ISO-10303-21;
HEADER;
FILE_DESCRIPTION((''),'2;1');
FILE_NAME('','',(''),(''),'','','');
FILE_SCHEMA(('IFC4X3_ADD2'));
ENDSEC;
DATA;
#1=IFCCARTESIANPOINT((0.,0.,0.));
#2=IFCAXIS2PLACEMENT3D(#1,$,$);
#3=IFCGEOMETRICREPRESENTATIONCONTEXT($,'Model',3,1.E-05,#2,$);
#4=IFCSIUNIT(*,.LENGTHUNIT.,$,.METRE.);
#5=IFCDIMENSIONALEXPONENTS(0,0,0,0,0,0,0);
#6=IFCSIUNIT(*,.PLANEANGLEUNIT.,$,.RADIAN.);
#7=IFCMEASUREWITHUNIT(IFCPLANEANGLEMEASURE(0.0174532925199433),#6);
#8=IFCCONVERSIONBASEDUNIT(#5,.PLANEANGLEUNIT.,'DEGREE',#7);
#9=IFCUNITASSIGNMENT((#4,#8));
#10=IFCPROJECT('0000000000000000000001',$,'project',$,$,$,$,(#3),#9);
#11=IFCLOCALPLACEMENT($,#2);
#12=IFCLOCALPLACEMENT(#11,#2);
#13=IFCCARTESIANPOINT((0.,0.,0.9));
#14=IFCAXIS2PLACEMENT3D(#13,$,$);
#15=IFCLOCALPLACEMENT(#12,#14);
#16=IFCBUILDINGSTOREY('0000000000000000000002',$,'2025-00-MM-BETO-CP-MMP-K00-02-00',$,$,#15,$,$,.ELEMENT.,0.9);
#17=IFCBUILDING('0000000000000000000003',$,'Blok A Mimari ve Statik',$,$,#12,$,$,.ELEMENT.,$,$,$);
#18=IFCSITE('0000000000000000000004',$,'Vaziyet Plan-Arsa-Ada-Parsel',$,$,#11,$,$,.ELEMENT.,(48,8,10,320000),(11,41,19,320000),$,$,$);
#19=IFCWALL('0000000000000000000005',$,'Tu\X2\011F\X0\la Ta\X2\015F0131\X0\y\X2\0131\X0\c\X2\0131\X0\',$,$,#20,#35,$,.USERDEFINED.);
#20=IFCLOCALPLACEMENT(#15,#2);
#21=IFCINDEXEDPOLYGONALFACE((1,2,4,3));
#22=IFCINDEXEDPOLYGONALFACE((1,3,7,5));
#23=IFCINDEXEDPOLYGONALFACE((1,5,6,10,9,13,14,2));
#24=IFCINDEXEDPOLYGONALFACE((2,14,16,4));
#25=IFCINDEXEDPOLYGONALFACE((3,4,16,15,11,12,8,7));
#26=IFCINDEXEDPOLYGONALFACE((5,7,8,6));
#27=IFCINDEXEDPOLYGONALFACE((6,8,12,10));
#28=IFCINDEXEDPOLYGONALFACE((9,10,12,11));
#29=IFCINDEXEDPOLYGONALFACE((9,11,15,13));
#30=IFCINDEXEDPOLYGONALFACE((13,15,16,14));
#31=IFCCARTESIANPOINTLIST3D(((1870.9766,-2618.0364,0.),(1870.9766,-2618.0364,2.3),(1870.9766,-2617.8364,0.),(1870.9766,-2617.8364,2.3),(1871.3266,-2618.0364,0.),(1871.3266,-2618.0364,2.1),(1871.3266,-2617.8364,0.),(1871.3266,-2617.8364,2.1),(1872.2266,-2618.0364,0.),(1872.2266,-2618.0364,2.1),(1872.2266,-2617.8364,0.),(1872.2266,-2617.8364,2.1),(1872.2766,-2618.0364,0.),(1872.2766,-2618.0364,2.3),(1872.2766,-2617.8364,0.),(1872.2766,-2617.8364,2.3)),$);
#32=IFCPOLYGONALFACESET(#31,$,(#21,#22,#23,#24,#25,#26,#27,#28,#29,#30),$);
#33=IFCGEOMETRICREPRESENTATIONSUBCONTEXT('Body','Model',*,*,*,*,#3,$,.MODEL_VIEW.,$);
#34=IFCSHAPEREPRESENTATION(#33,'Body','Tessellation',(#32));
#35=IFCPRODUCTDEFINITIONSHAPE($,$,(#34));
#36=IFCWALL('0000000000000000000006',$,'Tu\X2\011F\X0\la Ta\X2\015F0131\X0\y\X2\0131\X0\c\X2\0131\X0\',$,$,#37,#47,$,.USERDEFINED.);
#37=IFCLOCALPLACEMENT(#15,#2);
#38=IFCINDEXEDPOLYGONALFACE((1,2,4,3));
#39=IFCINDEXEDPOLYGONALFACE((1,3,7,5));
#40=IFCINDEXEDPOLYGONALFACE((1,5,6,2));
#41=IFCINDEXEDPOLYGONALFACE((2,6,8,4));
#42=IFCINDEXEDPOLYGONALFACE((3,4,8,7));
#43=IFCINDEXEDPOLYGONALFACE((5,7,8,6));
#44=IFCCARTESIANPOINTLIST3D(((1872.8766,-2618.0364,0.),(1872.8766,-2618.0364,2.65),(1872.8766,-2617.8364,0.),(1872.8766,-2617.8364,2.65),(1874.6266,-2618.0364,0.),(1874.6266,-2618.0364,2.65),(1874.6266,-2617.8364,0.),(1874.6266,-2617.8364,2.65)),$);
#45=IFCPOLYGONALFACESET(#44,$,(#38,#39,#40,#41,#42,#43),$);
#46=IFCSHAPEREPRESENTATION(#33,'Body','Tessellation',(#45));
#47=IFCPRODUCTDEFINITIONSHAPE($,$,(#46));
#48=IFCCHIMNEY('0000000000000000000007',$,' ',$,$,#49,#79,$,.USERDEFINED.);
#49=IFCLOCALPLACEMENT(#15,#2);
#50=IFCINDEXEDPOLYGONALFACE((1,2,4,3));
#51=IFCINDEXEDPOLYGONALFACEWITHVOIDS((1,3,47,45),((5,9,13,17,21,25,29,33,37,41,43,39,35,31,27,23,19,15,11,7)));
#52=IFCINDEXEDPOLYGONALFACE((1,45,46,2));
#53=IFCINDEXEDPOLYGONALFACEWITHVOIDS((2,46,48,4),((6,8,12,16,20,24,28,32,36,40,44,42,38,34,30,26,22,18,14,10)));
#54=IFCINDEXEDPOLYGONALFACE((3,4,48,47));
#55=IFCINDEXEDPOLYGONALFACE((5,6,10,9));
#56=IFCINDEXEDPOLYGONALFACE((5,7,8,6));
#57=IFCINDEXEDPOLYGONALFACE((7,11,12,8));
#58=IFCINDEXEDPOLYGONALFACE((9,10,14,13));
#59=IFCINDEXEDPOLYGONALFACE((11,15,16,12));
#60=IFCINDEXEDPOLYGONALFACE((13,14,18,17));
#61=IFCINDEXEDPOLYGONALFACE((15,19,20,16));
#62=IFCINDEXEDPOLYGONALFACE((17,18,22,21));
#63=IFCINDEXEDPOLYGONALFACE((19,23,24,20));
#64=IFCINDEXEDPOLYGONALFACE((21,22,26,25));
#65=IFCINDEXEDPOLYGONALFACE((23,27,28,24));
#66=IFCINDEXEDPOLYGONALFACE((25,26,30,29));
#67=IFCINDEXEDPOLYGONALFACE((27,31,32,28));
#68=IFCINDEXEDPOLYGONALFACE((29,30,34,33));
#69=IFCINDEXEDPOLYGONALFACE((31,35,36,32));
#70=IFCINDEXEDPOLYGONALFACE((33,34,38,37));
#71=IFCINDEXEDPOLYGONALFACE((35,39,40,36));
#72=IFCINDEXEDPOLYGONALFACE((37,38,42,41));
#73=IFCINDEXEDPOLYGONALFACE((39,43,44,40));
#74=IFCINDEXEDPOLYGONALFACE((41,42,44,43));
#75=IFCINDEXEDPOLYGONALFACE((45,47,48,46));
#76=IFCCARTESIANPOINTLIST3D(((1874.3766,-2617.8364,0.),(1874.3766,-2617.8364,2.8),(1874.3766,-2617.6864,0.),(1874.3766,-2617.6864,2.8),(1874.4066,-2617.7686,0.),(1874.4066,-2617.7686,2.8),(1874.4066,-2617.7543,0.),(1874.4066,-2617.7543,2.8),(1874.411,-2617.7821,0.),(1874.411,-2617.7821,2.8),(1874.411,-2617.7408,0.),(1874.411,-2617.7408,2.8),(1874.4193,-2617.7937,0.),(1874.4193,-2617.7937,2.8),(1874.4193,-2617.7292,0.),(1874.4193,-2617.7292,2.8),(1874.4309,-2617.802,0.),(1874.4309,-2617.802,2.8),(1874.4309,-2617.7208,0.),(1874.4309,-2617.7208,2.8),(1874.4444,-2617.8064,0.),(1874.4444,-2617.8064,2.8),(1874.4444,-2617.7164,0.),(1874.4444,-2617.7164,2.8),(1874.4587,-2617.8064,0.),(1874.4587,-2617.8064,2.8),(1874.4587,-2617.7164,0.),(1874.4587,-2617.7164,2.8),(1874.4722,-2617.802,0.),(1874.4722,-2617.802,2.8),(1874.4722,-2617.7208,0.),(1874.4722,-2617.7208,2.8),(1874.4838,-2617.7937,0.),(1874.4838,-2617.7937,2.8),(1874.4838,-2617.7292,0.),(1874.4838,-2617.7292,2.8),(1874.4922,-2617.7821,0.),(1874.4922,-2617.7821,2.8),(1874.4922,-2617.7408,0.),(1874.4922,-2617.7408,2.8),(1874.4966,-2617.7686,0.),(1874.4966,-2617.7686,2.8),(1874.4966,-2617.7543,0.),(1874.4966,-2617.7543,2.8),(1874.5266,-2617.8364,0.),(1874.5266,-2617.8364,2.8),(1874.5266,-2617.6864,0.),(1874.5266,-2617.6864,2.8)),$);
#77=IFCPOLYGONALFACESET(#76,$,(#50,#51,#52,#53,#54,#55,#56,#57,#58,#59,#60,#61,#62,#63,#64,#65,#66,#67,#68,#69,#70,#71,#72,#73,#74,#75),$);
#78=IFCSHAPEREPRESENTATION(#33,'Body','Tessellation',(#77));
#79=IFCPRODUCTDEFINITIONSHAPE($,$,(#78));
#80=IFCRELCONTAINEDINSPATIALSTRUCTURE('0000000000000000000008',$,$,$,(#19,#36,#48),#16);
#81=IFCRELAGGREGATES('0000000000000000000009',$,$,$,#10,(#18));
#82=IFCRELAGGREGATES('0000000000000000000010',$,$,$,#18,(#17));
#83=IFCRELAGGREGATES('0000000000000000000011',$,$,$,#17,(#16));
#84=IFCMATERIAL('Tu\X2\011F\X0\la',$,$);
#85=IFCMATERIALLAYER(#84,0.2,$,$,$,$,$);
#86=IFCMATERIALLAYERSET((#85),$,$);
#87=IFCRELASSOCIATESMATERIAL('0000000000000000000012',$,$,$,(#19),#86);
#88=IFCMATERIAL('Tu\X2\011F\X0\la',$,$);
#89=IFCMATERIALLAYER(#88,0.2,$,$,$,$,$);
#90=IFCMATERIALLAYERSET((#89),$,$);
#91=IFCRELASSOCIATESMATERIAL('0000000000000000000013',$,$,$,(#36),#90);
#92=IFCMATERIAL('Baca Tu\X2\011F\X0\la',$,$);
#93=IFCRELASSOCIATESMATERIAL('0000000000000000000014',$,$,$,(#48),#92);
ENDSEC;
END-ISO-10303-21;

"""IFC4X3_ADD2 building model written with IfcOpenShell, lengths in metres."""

from ifc_helpers import new_model, entity, si_unit, converted_unit, frame, frame_2d, origin, origin_with_axes, place, context, subcontext, project, spatial, polyline, rectangle, outline, extrude, material, layer, layer_set, layer_usage, element, save


model = new_model("IFC4X3_ADD2")

# Units and contexts
model_context = context("Model", 3, precision=1e-05, world=origin())
body_context = subcontext(model_context, "Body", "Model", "MODEL_VIEW")
ifc_project = project(units=[si_unit("LENGTHUNIT", "METRE"), converted_unit("PLANEANGLEUNIT", "DEGREE", entity("IfcPlaneAngleMeasure", 0.0174532925199433), si_unit("PLANEANGLEUNIT", "RADIAN"), dimensions=[0, 0, 0, 0, 0, 0, 0])], contexts=[model_context])

# Site, building, storey
site_placement = place(None, origin())
site = spatial("IfcSite", under=ifc_project, at=site_placement, Name="Vaziyet Plan-Arsa-Ada-Parsel", CompositionType="ELEMENT", RefLatitude=(48, 8, 10, 320000), RefLongitude=(11, 41, 19, 320000))
building_placement = place(site_placement, origin())
building = spatial("IfcBuilding", under=site, at=building_placement, Name="Blok A Mimari ve Statik", CompositionType="ELEMENT")
storey_placement = place(building_placement, frame((0.0, 0.0, 0.9)))
storey = spatial("IfcBuildingStorey", under=building, at=storey_placement, Name="2025-00-MM-BETO-CP-MMP-K00-02-00", CompositionType="ELEMENT", Elevation=0.9)

# Wall, opening
ifc_material_1 = material(Name="Tuğla")
ifc_layer_1 = layer(ifc_material_1, 0.2)
ifc_layer_set_1 = layer_set([ifc_layer_1])
ifc_layer_usage_1 = layer_usage(ifc_layer_set_1, "AXIS2", "POSITIVE", 0.0)
wall_1_placement = place(storey_placement, frame((1870.9766, -2618.0364, 0.0)))
wall_1 = element("IfcWall", 1, at=wall_1_placement, inside=storey, material=ifc_layer_usage_1, Name="Tuğla Taşıyıcı", PredefinedType="USERDEFINED", context=body_context, shape_type="SweptSolid", body=[
    extrude(rectangle(XDim=1.3, YDim=0.2, at=frame_2d((0.65, 0.1), x_axis=(1.0, 0.0))), origin_with_axes(), (0.0, 0.0, 1.0), 2.3),
])
opening_1_placement = place(wall_1_placement, frame((1.25, 0.2, 0.0), z_axis=(0.0, -1.0, 0.0), x_axis=(0.0, 0.0, 1.0)))
element("IfcOpeningElement", 2, at=opening_1_placement, cuts=wall_1, PredefinedType="OPENING", context=body_context, shape_type="SweptSolid", body=[
    extrude(outline(polyline([(2.1, 0.9), (2.1, 0.0), (0.0, 0.0), (0.0, 0.9), (2.1, 0.9)])), origin_with_axes(), (0.0, 0.0, 1.0), 0.2),
])

# Wall
ifc_material_2 = material(Name="Tuğla")
ifc_layer_2 = layer(ifc_material_2, 0.2)
ifc_layer_set_2 = layer_set([ifc_layer_2])
ifc_layer_usage_2 = layer_usage(ifc_layer_set_2, "AXIS2", "POSITIVE", 0.0)
wall_2_placement = place(storey_placement, frame((1872.8766, -2618.0364, 0.0)))
element("IfcWall", 3, at=wall_2_placement, inside=storey, material=ifc_layer_usage_2, Name="Tuğla Taşıyıcı", PredefinedType="USERDEFINED", context=body_context, shape_type="SweptSolid", body=[
    extrude(rectangle(XDim=1.75, YDim=0.2, at=frame_2d((0.875, 0.1), x_axis=(1.0, 0.0))), origin_with_axes(), (0.0, 0.0, 1.0), 2.65),
])

# Chimney
ifc_material_3 = material(Name="Baca Tuğla")
chimney_placement = place(storey_placement, frame((1874.3766, -2617.8364, 0.0)))
element("IfcChimney", 4, at=chimney_placement, inside=storey, material=ifc_material_3, Name=" ", PredefinedType="USERDEFINED", context=body_context, shape_type="SweptSolid", body=[
    extrude(outline(polyline([(0.0, 0.0), (0.15, 0.0), (0.15, 0.15), (0.0, 0.15), (0.0, 0.0)]), holes=[polyline([(0.1072, 0.0428), (0.0957, 0.0344), (0.0821, 0.03), (0.0679, 0.03), (0.0543, 0.0344), (0.0428, 0.0428), (0.0344, 0.0543), (0.03, 0.0679), (0.03, 0.0821), (0.0344, 0.0957), (0.0428, 0.1072), (0.0543, 0.1156), (0.0679, 0.12), (0.0821, 0.12), (0.0957, 0.1156), (0.1072, 0.1072), (0.1156, 0.0957), (0.12, 0.0821), (0.12, 0.0679), (0.1156, 0.0543), (0.1072, 0.0428)])]), origin_with_axes(), (0.0, 0.0, 1.0), 2.8),
])

save(model, "model.ifc")
